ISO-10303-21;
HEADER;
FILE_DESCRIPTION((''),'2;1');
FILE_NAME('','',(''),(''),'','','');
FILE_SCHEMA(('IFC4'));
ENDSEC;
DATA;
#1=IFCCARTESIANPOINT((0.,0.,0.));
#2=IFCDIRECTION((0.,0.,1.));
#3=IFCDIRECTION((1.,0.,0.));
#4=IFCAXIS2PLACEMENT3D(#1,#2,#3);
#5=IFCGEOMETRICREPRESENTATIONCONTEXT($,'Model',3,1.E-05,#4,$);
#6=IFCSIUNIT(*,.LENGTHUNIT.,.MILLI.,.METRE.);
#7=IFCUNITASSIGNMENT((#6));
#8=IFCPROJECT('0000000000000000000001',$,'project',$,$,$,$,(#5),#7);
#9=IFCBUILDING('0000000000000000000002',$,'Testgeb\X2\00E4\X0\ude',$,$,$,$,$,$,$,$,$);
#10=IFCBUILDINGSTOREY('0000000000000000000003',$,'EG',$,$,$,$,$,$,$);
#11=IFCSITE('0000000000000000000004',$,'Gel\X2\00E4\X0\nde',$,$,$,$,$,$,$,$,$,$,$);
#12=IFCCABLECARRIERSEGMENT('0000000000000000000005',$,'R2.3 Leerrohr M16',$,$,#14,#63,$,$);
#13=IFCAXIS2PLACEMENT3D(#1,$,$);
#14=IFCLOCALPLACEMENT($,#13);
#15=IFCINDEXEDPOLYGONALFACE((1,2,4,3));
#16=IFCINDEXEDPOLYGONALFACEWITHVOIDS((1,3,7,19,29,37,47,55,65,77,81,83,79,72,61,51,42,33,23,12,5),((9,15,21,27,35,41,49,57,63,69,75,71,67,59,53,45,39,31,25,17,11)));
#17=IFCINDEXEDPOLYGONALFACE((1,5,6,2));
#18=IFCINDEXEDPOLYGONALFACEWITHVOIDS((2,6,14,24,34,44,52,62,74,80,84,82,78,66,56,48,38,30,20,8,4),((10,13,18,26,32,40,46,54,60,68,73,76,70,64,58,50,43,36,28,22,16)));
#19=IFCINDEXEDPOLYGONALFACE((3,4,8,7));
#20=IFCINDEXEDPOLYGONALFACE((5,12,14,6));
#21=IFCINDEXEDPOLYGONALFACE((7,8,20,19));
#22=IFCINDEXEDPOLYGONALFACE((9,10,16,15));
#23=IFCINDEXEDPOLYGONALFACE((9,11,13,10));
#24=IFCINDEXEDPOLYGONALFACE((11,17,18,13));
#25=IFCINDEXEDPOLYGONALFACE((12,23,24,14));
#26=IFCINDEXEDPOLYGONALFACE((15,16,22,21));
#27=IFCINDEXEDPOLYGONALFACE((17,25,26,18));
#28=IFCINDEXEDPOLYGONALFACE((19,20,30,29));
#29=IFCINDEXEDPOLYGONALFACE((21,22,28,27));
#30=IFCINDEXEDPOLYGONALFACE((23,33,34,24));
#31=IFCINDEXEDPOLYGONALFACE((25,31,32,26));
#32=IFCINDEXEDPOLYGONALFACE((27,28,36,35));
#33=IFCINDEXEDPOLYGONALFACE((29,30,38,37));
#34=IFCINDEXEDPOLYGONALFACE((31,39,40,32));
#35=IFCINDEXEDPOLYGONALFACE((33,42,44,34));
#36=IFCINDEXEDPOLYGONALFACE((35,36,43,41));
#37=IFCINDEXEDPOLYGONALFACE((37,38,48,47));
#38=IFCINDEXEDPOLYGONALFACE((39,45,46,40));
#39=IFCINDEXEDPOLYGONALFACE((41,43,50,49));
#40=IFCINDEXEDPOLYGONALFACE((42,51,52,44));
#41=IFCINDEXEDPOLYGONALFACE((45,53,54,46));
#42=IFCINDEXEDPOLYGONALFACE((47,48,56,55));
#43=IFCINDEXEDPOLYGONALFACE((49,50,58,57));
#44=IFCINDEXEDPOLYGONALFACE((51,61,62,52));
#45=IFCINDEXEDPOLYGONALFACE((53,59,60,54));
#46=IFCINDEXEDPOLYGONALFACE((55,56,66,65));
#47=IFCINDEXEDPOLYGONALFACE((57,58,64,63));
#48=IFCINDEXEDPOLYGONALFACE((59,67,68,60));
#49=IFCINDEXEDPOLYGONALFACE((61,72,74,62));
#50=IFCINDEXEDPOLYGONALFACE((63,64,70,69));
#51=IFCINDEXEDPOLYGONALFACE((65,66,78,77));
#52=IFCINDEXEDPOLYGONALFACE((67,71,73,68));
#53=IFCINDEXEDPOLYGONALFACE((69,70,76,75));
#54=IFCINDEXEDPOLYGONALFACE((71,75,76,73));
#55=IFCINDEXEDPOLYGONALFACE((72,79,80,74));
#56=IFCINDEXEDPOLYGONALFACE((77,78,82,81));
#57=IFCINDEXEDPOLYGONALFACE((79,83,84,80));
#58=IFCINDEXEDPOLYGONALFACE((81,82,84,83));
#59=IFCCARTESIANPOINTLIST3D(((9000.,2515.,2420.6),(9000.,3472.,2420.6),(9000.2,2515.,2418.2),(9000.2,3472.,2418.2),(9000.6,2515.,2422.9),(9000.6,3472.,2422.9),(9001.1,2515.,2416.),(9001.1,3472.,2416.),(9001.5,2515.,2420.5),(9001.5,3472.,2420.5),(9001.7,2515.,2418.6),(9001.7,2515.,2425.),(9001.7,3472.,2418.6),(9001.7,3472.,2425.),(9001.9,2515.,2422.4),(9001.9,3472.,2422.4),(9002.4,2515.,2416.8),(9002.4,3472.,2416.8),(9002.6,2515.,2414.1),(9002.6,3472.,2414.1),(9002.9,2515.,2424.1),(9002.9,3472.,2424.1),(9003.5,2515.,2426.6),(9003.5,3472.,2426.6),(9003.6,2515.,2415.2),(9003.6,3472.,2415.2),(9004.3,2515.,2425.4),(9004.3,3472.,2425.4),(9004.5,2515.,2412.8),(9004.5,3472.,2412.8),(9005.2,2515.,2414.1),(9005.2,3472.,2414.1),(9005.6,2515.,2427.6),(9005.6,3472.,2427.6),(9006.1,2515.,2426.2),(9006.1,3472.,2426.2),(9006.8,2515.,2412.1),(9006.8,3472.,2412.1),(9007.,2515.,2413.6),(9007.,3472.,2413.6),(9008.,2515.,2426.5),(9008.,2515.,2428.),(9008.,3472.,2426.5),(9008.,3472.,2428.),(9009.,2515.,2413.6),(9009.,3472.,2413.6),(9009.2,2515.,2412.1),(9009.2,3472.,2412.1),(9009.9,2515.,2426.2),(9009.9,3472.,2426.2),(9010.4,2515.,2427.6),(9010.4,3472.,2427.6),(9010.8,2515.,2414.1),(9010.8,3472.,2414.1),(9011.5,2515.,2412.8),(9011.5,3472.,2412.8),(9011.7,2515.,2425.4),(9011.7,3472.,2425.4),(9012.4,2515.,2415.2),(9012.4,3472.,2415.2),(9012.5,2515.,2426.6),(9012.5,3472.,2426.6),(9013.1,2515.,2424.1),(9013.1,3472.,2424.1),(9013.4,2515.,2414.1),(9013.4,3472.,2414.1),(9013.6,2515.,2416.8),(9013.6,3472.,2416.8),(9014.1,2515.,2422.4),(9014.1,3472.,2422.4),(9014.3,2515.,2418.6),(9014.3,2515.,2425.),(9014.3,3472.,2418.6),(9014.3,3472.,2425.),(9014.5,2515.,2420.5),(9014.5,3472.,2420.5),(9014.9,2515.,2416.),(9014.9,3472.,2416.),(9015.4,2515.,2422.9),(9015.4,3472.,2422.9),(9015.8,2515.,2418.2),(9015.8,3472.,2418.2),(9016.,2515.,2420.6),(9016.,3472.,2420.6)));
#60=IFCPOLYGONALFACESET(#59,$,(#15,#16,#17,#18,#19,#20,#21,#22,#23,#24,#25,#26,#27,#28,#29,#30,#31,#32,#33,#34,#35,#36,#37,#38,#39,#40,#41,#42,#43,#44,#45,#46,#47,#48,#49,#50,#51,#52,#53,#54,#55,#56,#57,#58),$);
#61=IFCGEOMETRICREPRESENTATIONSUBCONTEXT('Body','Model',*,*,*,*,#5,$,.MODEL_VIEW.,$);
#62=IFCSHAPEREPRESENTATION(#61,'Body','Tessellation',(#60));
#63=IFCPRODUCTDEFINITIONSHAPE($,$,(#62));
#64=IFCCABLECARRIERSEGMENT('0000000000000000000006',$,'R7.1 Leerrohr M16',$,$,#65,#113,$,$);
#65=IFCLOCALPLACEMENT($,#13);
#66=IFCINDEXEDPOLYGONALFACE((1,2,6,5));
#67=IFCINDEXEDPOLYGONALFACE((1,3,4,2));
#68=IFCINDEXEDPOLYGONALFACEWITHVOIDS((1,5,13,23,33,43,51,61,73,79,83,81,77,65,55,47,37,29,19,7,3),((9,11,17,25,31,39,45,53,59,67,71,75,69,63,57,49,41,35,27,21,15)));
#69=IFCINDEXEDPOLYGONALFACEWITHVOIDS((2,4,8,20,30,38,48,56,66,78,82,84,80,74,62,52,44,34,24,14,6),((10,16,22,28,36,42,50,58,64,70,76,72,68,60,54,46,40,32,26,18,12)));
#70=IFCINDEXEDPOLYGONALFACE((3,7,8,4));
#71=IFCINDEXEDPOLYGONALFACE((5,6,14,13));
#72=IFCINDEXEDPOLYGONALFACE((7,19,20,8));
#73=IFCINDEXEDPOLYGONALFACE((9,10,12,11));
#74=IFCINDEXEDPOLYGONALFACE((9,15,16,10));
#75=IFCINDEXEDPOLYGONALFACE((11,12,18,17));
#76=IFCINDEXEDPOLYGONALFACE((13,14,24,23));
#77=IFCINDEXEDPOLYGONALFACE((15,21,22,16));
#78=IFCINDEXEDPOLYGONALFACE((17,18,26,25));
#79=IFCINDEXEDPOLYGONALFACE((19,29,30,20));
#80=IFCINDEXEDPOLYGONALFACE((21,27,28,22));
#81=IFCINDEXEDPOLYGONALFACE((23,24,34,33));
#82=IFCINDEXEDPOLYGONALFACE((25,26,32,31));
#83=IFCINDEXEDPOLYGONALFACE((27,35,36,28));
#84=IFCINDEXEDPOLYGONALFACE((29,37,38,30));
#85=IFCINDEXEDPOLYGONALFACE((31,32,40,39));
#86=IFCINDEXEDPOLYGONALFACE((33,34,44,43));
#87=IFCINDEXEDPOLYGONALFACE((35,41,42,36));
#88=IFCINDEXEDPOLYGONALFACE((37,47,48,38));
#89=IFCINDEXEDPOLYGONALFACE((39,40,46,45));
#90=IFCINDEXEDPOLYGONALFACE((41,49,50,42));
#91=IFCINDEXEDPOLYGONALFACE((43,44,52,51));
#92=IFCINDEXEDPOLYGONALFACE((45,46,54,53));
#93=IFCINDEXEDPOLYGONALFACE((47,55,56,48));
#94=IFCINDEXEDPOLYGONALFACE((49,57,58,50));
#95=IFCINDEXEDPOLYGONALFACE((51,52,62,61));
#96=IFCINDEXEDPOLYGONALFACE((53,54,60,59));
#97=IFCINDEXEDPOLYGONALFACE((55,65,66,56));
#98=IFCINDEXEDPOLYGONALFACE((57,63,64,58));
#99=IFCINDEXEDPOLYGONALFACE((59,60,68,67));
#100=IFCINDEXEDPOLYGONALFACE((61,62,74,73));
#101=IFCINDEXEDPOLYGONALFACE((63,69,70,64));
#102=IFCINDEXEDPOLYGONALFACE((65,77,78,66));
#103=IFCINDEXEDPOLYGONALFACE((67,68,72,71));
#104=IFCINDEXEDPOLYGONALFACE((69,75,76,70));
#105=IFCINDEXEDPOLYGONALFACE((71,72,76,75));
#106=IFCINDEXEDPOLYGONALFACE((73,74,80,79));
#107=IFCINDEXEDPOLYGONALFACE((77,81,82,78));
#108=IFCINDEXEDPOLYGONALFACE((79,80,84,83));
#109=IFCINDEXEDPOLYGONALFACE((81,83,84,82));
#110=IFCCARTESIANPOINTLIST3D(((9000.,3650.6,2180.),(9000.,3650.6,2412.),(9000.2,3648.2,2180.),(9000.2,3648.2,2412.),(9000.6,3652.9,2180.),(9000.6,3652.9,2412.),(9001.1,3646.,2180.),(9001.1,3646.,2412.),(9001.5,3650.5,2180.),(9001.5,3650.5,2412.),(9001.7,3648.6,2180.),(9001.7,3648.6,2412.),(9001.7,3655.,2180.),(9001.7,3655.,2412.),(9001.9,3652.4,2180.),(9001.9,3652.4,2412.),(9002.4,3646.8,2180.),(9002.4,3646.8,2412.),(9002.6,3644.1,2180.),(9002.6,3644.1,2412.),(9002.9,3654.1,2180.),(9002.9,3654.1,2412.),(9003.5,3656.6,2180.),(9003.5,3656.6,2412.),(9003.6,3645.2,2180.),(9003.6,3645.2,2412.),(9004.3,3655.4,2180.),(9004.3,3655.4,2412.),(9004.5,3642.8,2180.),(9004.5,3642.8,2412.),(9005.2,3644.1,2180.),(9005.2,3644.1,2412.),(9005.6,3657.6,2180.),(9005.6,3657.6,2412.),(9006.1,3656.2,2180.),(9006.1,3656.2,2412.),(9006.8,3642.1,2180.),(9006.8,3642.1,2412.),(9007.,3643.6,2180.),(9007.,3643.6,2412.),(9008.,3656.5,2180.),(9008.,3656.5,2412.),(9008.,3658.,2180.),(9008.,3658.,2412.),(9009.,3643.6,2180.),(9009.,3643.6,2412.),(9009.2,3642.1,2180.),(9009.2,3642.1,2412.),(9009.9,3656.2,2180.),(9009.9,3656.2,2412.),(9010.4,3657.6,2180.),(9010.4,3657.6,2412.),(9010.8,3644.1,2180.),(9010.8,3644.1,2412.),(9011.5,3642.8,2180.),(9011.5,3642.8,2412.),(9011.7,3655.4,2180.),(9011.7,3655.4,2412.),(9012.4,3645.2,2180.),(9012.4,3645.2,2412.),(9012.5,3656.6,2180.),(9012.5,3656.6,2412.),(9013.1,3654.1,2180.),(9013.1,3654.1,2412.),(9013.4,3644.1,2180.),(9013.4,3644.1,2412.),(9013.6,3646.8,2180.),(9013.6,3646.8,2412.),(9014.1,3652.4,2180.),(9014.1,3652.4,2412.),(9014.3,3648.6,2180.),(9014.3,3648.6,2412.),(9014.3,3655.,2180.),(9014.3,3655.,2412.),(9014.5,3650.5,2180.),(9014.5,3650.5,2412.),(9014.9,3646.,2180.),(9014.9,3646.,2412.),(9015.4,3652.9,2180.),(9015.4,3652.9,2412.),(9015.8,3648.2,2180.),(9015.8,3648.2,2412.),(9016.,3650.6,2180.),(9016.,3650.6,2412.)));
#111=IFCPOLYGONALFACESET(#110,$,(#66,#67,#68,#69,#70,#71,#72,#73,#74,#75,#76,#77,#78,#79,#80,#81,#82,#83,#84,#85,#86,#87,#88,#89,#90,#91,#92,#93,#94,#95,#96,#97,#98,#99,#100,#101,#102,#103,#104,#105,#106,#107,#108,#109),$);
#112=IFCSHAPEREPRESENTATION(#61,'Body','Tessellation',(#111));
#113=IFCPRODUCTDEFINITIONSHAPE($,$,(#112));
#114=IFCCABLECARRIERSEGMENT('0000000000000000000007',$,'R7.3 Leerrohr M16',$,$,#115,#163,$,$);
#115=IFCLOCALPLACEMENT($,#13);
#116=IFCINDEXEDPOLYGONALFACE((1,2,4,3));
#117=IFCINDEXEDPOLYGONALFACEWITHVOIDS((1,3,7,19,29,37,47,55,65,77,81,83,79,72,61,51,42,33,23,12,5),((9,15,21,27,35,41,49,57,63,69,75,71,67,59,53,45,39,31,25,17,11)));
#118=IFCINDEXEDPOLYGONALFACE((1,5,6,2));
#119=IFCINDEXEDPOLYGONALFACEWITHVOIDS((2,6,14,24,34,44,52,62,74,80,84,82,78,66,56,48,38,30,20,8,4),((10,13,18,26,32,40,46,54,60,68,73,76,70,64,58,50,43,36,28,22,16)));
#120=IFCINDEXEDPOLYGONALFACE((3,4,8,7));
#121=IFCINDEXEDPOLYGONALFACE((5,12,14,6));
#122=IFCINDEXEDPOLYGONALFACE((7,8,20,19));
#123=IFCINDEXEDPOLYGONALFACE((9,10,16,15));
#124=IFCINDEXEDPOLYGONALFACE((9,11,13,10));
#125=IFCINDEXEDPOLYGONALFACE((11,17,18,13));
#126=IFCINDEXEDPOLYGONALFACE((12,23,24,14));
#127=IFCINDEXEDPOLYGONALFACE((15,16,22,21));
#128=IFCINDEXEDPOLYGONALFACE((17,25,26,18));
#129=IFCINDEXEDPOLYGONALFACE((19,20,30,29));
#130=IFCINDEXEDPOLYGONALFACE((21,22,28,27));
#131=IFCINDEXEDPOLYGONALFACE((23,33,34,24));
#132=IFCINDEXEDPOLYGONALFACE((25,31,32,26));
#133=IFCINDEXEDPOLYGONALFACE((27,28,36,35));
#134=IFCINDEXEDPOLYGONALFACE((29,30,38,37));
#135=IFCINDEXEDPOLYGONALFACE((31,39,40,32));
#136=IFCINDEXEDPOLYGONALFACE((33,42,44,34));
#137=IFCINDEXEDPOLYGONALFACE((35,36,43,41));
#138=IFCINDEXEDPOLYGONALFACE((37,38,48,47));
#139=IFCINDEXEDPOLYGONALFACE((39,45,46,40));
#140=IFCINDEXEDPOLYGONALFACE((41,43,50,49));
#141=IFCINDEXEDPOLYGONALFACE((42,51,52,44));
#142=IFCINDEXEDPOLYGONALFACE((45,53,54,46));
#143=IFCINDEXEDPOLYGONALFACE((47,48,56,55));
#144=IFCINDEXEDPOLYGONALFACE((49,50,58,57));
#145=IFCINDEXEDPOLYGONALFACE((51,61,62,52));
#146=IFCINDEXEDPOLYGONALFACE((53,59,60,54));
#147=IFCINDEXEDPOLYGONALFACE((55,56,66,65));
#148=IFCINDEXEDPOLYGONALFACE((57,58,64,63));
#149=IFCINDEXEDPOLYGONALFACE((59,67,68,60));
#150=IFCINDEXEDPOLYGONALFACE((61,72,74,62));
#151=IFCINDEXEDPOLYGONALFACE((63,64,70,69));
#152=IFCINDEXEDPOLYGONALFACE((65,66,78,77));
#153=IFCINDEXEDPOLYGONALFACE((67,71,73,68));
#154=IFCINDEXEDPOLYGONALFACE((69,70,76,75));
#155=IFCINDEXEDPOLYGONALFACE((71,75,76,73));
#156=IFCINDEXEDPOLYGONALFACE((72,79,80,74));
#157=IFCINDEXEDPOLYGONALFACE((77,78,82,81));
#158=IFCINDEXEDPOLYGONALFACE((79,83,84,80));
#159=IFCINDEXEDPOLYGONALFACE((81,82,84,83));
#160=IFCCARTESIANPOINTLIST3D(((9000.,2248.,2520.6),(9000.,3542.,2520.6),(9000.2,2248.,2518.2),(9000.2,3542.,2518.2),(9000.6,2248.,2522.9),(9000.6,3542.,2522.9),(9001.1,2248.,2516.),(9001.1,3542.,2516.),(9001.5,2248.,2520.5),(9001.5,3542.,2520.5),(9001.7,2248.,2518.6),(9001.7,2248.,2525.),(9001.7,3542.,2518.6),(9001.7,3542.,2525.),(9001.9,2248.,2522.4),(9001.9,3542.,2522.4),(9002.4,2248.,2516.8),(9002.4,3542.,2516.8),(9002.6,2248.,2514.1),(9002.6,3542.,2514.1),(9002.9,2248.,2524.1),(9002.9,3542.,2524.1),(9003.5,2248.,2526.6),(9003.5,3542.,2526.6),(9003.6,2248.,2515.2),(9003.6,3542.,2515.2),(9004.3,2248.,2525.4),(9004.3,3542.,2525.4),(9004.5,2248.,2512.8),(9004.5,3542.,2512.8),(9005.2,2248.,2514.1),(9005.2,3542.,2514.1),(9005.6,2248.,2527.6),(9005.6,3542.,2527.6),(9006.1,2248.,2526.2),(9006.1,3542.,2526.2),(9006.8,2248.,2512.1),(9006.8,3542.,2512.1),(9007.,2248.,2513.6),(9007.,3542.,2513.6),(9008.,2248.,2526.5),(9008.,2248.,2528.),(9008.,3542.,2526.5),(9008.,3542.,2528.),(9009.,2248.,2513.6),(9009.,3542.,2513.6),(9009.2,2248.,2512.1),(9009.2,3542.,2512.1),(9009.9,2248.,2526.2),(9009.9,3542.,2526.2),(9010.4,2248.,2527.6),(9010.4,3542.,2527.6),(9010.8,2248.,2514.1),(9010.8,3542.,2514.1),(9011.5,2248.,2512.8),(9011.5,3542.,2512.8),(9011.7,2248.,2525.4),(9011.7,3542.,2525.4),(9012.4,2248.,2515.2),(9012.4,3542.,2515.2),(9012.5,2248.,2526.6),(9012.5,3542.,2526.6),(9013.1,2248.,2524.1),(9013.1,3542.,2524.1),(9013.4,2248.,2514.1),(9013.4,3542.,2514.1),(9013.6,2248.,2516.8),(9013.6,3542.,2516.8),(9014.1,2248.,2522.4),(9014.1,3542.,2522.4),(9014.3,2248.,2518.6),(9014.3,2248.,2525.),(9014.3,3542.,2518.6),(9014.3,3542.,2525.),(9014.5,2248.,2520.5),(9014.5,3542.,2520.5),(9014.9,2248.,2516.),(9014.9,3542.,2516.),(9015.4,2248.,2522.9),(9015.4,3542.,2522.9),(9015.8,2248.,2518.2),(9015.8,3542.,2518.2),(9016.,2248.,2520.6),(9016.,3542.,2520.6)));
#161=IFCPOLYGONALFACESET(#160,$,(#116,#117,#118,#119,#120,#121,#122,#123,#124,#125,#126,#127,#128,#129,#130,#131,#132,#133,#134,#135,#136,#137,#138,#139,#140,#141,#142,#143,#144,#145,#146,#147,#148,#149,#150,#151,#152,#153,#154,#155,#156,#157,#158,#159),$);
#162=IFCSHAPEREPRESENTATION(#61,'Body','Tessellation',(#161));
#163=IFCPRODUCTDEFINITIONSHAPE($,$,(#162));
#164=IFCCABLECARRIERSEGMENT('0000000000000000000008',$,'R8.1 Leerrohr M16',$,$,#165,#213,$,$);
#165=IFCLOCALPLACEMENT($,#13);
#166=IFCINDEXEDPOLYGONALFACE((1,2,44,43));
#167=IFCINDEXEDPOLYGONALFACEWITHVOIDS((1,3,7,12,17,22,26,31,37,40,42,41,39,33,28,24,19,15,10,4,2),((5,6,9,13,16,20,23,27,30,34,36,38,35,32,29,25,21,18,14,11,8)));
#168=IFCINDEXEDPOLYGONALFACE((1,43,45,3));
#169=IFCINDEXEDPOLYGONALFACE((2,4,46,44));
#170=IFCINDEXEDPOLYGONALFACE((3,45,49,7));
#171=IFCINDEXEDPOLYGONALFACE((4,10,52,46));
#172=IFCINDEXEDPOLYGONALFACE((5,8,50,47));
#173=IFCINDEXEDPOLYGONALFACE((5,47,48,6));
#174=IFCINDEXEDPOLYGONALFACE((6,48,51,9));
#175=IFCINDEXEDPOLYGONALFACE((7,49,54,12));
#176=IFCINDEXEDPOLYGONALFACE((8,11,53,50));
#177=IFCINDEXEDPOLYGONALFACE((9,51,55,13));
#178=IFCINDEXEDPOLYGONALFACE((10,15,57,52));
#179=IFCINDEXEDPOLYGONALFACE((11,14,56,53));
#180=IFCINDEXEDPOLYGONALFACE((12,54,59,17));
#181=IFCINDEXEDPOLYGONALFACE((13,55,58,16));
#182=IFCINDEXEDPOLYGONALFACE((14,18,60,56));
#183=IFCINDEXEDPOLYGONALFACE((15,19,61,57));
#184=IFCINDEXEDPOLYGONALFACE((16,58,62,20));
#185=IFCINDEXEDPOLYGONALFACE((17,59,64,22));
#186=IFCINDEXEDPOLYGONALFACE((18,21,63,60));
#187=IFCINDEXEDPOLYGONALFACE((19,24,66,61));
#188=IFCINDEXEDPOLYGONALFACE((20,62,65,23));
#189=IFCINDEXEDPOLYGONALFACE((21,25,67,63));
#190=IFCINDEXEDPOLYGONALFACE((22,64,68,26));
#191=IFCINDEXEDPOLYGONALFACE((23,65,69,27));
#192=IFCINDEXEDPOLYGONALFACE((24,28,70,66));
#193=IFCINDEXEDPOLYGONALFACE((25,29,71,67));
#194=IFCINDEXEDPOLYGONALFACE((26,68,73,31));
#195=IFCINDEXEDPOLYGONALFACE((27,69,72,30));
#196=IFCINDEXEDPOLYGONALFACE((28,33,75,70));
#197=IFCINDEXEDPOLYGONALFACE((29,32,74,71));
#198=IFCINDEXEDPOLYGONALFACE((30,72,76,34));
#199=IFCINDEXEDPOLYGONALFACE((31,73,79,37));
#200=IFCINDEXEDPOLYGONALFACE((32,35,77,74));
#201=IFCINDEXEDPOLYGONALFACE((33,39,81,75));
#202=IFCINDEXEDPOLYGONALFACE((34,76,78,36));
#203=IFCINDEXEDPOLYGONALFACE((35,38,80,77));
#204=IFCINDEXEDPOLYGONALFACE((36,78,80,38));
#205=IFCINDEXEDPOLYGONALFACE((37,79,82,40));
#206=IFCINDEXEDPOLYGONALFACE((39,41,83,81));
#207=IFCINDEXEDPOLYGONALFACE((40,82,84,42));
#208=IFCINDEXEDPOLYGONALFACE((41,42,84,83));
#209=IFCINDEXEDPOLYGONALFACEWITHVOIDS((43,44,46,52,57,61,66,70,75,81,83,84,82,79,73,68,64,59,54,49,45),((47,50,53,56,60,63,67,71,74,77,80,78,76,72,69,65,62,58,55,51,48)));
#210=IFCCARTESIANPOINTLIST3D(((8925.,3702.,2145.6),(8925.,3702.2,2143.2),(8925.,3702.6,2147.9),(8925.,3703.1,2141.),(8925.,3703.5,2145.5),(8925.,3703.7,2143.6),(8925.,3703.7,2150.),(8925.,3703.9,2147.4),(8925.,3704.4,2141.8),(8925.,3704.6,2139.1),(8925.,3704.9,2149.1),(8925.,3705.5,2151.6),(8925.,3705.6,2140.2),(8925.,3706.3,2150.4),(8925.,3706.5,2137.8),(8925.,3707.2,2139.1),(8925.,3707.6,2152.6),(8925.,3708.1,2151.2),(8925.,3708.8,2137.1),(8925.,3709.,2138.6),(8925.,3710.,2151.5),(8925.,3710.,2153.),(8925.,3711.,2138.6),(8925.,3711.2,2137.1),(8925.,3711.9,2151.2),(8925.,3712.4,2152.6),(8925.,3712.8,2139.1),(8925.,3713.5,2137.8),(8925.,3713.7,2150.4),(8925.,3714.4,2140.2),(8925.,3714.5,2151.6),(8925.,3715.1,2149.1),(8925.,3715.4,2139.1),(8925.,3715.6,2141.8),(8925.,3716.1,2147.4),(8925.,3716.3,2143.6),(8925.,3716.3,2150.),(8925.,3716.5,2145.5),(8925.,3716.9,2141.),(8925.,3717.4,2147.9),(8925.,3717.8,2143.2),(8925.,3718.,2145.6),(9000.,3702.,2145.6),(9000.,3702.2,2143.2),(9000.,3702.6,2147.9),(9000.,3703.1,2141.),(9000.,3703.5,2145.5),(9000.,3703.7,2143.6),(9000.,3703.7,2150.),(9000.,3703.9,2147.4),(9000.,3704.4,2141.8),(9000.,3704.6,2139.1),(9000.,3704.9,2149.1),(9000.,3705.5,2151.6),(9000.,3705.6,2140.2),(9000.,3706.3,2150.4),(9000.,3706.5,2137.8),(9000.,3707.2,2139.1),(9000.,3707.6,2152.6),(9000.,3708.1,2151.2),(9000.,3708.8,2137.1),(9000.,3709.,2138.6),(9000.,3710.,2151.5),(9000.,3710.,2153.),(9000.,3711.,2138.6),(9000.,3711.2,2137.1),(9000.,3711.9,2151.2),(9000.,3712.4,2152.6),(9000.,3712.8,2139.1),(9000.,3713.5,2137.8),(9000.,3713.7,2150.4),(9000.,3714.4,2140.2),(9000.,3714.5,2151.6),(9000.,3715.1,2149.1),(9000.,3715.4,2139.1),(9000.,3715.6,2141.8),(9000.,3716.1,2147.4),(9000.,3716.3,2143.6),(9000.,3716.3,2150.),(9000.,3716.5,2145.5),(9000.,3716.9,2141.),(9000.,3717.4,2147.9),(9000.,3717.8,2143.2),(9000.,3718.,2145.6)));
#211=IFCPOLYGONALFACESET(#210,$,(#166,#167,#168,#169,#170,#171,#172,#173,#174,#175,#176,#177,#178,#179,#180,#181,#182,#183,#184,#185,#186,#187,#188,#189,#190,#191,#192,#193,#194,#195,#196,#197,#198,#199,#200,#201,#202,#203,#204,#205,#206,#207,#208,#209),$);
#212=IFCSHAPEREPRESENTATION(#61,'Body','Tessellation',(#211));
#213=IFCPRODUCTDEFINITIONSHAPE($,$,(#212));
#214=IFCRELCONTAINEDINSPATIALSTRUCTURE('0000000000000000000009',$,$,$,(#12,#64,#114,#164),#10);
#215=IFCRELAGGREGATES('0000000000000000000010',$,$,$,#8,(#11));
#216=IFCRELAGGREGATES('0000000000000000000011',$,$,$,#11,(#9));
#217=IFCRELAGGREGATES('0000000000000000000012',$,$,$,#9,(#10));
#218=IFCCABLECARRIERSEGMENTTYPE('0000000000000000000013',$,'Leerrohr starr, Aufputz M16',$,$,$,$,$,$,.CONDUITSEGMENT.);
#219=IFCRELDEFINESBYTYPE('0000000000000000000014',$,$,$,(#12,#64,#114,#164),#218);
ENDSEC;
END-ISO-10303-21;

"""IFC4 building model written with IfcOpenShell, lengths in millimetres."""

from ifc_helpers import new_model, si_unit, frame, origin_with_axes, place, context, subcontext, project, spatial, hollow_circle, extrude, type_object, element, save


model = new_model("IFC4")

# Units and contexts
model_context = context("Model", 3, precision=1e-05, world=origin_with_axes())
body_context = subcontext(model_context, "Body", "Model", "MODEL_VIEW")
ifc_project = project(units=[si_unit("LENGTHUNIT", "METRE", prefix="MILLI")], contexts=[model_context])

# Site, building, storey
site = spatial("IfcSite", under=ifc_project, Name="Gelände")
building = spatial("IfcBuilding", under=site, Name="Testgebäude")
storey = spatial("IfcBuildingStorey", under=building, Name="EG")

# Cable carrier segments
cable_carrier_segment_type_1 = type_object("IfcCableCarrierSegmentType", Name="Leerrohr starr, Aufputz M16", PredefinedType="CONDUITSEGMENT")
cable_carrier_segment_1_placement = place(None, frame((9008.0, 3472.0, 2420.0), z_axis=(0.0, -1.0, 0.0), x_axis=(0.0, 0.0, 1.0)))
element("IfcCableCarrierSegment", 1, at=cable_carrier_segment_1_placement, inside=storey, type_object=cable_carrier_segment_type_1, Name="R2.3 Leerrohr M16", context=body_context, shape_type="SweptSolid", body=[
    extrude(hollow_circle(Radius=8.0, WallThickness=1.5), None, (0.0, 0.0, 1.0), 957.0),
])
cable_carrier_segment_2_placement = place(None, frame((9008.0, 3650.0, 2180.0), z_axis=(0.0, 0.0, 1.0), x_axis=(0.0, 1.0, 0.0)))
element("IfcCableCarrierSegment", 2, at=cable_carrier_segment_2_placement, inside=storey, type_object=cable_carrier_segment_type_1, Name="R7.1 Leerrohr M16", context=body_context, shape_type="SweptSolid", body=[
    extrude(hollow_circle(Radius=8.0, WallThickness=1.5), None, (0.0, 0.0, 1.0), 232.0),
])
cable_carrier_segment_3_placement = place(None, frame((9008.0, 3542.0, 2520.0), z_axis=(0.0, -1.0, 0.0), x_axis=(0.0, 0.0, 1.0)))
element("IfcCableCarrierSegment", 3, at=cable_carrier_segment_3_placement, inside=storey, type_object=cable_carrier_segment_type_1, Name="R7.3 Leerrohr M16", context=body_context, shape_type="SweptSolid", body=[
    extrude(hollow_circle(Radius=8.0, WallThickness=1.5), None, (0.0, 0.0, 1.0), 1294.0),
])
cable_carrier_segment_4_placement = place(None, frame((9000.0, 3710.0, 2145.0), z_axis=(-1.0, 0.0, 0.0), x_axis=(0.0, 0.0, 1.0)))
element("IfcCableCarrierSegment", 4, at=cable_carrier_segment_4_placement, inside=storey, type_object=cable_carrier_segment_type_1, Name="R8.1 Leerrohr M16", context=body_context, shape_type="SweptSolid", body=[
    extrude(hollow_circle(Radius=8.0, WallThickness=1.5), None, (0.0, 0.0, 1.0), 75.0),
])

save(model, "model.ifc")
